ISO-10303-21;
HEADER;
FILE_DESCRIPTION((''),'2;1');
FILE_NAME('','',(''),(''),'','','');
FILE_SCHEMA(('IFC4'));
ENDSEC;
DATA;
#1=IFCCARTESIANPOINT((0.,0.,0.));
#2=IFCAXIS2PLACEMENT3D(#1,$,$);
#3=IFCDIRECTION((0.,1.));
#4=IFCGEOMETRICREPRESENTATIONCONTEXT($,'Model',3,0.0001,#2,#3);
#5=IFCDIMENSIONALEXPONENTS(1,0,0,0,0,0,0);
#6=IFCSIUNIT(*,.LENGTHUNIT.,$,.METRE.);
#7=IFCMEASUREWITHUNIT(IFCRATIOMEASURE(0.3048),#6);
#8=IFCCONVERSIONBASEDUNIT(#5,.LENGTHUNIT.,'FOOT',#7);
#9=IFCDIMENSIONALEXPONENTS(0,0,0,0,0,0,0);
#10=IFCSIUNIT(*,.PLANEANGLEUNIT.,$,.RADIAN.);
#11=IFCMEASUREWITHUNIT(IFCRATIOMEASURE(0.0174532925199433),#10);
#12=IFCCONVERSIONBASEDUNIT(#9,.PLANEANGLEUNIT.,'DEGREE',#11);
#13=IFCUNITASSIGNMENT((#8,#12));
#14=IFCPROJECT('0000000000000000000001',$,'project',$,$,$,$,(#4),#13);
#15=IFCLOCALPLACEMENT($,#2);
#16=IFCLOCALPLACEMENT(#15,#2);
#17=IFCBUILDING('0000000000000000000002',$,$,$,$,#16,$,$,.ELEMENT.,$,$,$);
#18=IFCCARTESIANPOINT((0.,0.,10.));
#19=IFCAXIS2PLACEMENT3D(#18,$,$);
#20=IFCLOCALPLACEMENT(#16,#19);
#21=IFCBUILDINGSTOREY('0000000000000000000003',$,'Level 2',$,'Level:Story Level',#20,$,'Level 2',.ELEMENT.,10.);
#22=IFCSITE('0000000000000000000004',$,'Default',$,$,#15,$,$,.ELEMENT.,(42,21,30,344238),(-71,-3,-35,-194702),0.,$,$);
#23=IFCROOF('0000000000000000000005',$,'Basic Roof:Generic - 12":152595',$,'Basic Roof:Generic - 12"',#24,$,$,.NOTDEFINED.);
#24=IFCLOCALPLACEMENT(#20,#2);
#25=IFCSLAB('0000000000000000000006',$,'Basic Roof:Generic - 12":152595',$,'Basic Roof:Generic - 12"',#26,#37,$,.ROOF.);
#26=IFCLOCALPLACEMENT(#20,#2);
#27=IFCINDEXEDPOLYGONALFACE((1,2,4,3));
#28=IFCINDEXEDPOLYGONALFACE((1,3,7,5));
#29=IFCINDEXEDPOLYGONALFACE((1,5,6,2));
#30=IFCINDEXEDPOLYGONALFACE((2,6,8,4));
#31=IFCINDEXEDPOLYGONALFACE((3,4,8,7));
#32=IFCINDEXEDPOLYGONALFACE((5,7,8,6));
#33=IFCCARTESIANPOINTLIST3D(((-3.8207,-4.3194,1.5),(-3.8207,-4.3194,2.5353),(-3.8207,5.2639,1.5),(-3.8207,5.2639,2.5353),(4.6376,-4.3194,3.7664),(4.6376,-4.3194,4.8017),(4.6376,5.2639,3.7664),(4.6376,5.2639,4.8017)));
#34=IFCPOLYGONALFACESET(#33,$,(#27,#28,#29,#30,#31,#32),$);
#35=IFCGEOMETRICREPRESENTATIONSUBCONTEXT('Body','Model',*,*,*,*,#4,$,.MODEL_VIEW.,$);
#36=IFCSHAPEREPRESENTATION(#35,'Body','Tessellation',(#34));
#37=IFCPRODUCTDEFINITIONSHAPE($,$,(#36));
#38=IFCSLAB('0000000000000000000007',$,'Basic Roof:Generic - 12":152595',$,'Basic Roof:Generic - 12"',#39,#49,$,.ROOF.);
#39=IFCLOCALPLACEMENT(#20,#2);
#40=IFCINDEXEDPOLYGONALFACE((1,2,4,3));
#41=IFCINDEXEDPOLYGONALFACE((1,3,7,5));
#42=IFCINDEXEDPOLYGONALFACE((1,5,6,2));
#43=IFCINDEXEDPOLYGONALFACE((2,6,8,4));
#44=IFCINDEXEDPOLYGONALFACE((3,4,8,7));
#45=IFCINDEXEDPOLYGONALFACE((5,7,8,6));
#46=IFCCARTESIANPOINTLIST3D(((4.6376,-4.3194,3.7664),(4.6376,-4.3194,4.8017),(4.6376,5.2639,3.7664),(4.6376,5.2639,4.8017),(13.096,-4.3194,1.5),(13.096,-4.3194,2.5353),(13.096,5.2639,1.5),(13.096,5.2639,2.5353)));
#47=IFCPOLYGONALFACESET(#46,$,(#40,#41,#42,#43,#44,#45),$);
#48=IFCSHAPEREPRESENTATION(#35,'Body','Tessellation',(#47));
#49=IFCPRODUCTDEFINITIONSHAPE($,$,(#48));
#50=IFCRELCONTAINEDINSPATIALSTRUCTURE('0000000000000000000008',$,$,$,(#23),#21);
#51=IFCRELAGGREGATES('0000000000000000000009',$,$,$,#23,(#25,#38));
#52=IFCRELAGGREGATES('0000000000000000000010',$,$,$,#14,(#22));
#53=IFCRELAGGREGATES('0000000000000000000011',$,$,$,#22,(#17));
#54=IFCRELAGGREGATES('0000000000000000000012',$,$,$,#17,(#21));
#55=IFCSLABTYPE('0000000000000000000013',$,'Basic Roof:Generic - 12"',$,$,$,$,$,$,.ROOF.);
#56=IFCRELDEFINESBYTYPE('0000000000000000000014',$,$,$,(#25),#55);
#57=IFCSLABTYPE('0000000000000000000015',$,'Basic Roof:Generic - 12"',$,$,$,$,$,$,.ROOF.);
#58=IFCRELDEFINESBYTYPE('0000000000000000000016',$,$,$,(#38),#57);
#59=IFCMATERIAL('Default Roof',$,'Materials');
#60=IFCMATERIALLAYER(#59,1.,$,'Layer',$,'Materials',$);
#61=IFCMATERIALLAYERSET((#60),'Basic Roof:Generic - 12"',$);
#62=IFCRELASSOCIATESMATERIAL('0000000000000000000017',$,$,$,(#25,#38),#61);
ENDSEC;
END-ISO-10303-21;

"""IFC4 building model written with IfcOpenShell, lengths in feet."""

from ifc_helpers import new_model, entity, si_unit, converted_unit, direction, frame, frame_2d, origin, origin_2d_with_axis, place, context, subcontext, project, spatial, rectangle, extrude, material, layer, layer_set, type_object, element, aggregate, save


model = new_model("IFC4")

# Units and contexts
model_context = context("Model", 3, precision=0.0001, world=origin(), true_north=direction((0.0, 1.0)))
body_context = subcontext(model_context, "Body", "Model", "MODEL_VIEW")
ifc_project = project(units=[converted_unit("LENGTHUNIT", "FOOT", entity("IfcRatioMeasure", 0.3048), si_unit("LENGTHUNIT", "METRE"), dimensions=[1, 0, 0, 0, 0, 0, 0]), converted_unit("PLANEANGLEUNIT", "DEGREE", entity("IfcRatioMeasure", 0.0174532925199433), si_unit("PLANEANGLEUNIT", "RADIAN"), dimensions=[0, 0, 0, 0, 0, 0, 0])], contexts=[model_context])

# Site, building, storey
site_placement = place(None, origin())
site = spatial("IfcSite", under=ifc_project, at=site_placement, Name="Default", CompositionType="ELEMENT", RefLatitude=(42, 21, 30, 344238), RefLongitude=(-71, -3, -35, -194702), RefElevation=0.0)
building_placement = place(site_placement, origin())
building = spatial("IfcBuilding", under=site, at=building_placement, CompositionType="ELEMENT")
storey_placement = place(building_placement, frame((0.0, 0.0, 10.0)))
storey = spatial("IfcBuildingStorey", under=building, at=storey_placement, Name="Level 2", ObjectType="Level:Story Level", LongName="Level 2", CompositionType="ELEMENT", Elevation=10.0)

# Roof, slabs
roof_placement = place(storey_placement, frame((-3.8207, -4.3194, 1.5)))
roof = element("IfcRoof", 1, at=roof_placement, inside=storey, Name="Basic Roof:Generic - 12\":152595", ObjectType="Basic Roof:Generic - 12\"", PredefinedType="NOTDEFINED")
ifc_material = material(Name="Default Roof", Category="Materials")
ifc_layer = layer(ifc_material, 1.0, Name="Layer", Category="Materials")
ifc_layer_set = layer_set([ifc_layer], Name="Basic Roof:Generic - 12\"")
slab_type_1 = type_object("IfcSlabType", Name="Basic Roof:Generic - 12\"", PredefinedType="ROOF")
slab_1_placement = place(roof_placement, origin())
slab_1 = element("IfcSlab", 2, at=slab_1_placement, type_object=slab_type_1, material=ifc_layer_set, Name="Basic Roof:Generic - 12\":152595", ObjectType="Basic Roof:Generic - 12\"", PredefinedType="ROOF", context=body_context, shape_type="SweptSolid", body=[
    extrude(rectangle(XDim=9.5833, YDim=8.7567, at=frame_2d((0.0, 0.0), x_axis=(0.0, 1.0))), frame((4.2292, 4.7917, 1.1332), z_axis=(-0.258819, 0.0, 0.965926), x_axis=(0.965926, 0.0, 0.258819)), (0.258819, 0.0, 0.965926), 1.0353),
])
slab_type_2 = type_object("IfcSlabType", Name="Basic Roof:Generic - 12\"", PredefinedType="ROOF")
slab_2_placement = place(roof_placement, origin())
slab_2 = element("IfcSlab", 3, at=slab_2_placement, type_object=slab_type_2, material=ifc_layer_set, Name="Basic Roof:Generic - 12\":152595", ObjectType="Basic Roof:Generic - 12\"", PredefinedType="ROOF", context=body_context, shape_type="SweptSolid", body=[
    extrude(rectangle(XDim=8.7567, YDim=9.5833, at=origin_2d_with_axis()), frame((12.6875, 4.7917, 1.1332), z_axis=(0.258819, 0.0, 0.965926), x_axis=(0.965926, 0.0, -0.258819)), (-0.258819, 0.0, 0.965926), 1.0353),
])
aggregate(roof, [slab_1, slab_2])

save(model, "model.ifc")
